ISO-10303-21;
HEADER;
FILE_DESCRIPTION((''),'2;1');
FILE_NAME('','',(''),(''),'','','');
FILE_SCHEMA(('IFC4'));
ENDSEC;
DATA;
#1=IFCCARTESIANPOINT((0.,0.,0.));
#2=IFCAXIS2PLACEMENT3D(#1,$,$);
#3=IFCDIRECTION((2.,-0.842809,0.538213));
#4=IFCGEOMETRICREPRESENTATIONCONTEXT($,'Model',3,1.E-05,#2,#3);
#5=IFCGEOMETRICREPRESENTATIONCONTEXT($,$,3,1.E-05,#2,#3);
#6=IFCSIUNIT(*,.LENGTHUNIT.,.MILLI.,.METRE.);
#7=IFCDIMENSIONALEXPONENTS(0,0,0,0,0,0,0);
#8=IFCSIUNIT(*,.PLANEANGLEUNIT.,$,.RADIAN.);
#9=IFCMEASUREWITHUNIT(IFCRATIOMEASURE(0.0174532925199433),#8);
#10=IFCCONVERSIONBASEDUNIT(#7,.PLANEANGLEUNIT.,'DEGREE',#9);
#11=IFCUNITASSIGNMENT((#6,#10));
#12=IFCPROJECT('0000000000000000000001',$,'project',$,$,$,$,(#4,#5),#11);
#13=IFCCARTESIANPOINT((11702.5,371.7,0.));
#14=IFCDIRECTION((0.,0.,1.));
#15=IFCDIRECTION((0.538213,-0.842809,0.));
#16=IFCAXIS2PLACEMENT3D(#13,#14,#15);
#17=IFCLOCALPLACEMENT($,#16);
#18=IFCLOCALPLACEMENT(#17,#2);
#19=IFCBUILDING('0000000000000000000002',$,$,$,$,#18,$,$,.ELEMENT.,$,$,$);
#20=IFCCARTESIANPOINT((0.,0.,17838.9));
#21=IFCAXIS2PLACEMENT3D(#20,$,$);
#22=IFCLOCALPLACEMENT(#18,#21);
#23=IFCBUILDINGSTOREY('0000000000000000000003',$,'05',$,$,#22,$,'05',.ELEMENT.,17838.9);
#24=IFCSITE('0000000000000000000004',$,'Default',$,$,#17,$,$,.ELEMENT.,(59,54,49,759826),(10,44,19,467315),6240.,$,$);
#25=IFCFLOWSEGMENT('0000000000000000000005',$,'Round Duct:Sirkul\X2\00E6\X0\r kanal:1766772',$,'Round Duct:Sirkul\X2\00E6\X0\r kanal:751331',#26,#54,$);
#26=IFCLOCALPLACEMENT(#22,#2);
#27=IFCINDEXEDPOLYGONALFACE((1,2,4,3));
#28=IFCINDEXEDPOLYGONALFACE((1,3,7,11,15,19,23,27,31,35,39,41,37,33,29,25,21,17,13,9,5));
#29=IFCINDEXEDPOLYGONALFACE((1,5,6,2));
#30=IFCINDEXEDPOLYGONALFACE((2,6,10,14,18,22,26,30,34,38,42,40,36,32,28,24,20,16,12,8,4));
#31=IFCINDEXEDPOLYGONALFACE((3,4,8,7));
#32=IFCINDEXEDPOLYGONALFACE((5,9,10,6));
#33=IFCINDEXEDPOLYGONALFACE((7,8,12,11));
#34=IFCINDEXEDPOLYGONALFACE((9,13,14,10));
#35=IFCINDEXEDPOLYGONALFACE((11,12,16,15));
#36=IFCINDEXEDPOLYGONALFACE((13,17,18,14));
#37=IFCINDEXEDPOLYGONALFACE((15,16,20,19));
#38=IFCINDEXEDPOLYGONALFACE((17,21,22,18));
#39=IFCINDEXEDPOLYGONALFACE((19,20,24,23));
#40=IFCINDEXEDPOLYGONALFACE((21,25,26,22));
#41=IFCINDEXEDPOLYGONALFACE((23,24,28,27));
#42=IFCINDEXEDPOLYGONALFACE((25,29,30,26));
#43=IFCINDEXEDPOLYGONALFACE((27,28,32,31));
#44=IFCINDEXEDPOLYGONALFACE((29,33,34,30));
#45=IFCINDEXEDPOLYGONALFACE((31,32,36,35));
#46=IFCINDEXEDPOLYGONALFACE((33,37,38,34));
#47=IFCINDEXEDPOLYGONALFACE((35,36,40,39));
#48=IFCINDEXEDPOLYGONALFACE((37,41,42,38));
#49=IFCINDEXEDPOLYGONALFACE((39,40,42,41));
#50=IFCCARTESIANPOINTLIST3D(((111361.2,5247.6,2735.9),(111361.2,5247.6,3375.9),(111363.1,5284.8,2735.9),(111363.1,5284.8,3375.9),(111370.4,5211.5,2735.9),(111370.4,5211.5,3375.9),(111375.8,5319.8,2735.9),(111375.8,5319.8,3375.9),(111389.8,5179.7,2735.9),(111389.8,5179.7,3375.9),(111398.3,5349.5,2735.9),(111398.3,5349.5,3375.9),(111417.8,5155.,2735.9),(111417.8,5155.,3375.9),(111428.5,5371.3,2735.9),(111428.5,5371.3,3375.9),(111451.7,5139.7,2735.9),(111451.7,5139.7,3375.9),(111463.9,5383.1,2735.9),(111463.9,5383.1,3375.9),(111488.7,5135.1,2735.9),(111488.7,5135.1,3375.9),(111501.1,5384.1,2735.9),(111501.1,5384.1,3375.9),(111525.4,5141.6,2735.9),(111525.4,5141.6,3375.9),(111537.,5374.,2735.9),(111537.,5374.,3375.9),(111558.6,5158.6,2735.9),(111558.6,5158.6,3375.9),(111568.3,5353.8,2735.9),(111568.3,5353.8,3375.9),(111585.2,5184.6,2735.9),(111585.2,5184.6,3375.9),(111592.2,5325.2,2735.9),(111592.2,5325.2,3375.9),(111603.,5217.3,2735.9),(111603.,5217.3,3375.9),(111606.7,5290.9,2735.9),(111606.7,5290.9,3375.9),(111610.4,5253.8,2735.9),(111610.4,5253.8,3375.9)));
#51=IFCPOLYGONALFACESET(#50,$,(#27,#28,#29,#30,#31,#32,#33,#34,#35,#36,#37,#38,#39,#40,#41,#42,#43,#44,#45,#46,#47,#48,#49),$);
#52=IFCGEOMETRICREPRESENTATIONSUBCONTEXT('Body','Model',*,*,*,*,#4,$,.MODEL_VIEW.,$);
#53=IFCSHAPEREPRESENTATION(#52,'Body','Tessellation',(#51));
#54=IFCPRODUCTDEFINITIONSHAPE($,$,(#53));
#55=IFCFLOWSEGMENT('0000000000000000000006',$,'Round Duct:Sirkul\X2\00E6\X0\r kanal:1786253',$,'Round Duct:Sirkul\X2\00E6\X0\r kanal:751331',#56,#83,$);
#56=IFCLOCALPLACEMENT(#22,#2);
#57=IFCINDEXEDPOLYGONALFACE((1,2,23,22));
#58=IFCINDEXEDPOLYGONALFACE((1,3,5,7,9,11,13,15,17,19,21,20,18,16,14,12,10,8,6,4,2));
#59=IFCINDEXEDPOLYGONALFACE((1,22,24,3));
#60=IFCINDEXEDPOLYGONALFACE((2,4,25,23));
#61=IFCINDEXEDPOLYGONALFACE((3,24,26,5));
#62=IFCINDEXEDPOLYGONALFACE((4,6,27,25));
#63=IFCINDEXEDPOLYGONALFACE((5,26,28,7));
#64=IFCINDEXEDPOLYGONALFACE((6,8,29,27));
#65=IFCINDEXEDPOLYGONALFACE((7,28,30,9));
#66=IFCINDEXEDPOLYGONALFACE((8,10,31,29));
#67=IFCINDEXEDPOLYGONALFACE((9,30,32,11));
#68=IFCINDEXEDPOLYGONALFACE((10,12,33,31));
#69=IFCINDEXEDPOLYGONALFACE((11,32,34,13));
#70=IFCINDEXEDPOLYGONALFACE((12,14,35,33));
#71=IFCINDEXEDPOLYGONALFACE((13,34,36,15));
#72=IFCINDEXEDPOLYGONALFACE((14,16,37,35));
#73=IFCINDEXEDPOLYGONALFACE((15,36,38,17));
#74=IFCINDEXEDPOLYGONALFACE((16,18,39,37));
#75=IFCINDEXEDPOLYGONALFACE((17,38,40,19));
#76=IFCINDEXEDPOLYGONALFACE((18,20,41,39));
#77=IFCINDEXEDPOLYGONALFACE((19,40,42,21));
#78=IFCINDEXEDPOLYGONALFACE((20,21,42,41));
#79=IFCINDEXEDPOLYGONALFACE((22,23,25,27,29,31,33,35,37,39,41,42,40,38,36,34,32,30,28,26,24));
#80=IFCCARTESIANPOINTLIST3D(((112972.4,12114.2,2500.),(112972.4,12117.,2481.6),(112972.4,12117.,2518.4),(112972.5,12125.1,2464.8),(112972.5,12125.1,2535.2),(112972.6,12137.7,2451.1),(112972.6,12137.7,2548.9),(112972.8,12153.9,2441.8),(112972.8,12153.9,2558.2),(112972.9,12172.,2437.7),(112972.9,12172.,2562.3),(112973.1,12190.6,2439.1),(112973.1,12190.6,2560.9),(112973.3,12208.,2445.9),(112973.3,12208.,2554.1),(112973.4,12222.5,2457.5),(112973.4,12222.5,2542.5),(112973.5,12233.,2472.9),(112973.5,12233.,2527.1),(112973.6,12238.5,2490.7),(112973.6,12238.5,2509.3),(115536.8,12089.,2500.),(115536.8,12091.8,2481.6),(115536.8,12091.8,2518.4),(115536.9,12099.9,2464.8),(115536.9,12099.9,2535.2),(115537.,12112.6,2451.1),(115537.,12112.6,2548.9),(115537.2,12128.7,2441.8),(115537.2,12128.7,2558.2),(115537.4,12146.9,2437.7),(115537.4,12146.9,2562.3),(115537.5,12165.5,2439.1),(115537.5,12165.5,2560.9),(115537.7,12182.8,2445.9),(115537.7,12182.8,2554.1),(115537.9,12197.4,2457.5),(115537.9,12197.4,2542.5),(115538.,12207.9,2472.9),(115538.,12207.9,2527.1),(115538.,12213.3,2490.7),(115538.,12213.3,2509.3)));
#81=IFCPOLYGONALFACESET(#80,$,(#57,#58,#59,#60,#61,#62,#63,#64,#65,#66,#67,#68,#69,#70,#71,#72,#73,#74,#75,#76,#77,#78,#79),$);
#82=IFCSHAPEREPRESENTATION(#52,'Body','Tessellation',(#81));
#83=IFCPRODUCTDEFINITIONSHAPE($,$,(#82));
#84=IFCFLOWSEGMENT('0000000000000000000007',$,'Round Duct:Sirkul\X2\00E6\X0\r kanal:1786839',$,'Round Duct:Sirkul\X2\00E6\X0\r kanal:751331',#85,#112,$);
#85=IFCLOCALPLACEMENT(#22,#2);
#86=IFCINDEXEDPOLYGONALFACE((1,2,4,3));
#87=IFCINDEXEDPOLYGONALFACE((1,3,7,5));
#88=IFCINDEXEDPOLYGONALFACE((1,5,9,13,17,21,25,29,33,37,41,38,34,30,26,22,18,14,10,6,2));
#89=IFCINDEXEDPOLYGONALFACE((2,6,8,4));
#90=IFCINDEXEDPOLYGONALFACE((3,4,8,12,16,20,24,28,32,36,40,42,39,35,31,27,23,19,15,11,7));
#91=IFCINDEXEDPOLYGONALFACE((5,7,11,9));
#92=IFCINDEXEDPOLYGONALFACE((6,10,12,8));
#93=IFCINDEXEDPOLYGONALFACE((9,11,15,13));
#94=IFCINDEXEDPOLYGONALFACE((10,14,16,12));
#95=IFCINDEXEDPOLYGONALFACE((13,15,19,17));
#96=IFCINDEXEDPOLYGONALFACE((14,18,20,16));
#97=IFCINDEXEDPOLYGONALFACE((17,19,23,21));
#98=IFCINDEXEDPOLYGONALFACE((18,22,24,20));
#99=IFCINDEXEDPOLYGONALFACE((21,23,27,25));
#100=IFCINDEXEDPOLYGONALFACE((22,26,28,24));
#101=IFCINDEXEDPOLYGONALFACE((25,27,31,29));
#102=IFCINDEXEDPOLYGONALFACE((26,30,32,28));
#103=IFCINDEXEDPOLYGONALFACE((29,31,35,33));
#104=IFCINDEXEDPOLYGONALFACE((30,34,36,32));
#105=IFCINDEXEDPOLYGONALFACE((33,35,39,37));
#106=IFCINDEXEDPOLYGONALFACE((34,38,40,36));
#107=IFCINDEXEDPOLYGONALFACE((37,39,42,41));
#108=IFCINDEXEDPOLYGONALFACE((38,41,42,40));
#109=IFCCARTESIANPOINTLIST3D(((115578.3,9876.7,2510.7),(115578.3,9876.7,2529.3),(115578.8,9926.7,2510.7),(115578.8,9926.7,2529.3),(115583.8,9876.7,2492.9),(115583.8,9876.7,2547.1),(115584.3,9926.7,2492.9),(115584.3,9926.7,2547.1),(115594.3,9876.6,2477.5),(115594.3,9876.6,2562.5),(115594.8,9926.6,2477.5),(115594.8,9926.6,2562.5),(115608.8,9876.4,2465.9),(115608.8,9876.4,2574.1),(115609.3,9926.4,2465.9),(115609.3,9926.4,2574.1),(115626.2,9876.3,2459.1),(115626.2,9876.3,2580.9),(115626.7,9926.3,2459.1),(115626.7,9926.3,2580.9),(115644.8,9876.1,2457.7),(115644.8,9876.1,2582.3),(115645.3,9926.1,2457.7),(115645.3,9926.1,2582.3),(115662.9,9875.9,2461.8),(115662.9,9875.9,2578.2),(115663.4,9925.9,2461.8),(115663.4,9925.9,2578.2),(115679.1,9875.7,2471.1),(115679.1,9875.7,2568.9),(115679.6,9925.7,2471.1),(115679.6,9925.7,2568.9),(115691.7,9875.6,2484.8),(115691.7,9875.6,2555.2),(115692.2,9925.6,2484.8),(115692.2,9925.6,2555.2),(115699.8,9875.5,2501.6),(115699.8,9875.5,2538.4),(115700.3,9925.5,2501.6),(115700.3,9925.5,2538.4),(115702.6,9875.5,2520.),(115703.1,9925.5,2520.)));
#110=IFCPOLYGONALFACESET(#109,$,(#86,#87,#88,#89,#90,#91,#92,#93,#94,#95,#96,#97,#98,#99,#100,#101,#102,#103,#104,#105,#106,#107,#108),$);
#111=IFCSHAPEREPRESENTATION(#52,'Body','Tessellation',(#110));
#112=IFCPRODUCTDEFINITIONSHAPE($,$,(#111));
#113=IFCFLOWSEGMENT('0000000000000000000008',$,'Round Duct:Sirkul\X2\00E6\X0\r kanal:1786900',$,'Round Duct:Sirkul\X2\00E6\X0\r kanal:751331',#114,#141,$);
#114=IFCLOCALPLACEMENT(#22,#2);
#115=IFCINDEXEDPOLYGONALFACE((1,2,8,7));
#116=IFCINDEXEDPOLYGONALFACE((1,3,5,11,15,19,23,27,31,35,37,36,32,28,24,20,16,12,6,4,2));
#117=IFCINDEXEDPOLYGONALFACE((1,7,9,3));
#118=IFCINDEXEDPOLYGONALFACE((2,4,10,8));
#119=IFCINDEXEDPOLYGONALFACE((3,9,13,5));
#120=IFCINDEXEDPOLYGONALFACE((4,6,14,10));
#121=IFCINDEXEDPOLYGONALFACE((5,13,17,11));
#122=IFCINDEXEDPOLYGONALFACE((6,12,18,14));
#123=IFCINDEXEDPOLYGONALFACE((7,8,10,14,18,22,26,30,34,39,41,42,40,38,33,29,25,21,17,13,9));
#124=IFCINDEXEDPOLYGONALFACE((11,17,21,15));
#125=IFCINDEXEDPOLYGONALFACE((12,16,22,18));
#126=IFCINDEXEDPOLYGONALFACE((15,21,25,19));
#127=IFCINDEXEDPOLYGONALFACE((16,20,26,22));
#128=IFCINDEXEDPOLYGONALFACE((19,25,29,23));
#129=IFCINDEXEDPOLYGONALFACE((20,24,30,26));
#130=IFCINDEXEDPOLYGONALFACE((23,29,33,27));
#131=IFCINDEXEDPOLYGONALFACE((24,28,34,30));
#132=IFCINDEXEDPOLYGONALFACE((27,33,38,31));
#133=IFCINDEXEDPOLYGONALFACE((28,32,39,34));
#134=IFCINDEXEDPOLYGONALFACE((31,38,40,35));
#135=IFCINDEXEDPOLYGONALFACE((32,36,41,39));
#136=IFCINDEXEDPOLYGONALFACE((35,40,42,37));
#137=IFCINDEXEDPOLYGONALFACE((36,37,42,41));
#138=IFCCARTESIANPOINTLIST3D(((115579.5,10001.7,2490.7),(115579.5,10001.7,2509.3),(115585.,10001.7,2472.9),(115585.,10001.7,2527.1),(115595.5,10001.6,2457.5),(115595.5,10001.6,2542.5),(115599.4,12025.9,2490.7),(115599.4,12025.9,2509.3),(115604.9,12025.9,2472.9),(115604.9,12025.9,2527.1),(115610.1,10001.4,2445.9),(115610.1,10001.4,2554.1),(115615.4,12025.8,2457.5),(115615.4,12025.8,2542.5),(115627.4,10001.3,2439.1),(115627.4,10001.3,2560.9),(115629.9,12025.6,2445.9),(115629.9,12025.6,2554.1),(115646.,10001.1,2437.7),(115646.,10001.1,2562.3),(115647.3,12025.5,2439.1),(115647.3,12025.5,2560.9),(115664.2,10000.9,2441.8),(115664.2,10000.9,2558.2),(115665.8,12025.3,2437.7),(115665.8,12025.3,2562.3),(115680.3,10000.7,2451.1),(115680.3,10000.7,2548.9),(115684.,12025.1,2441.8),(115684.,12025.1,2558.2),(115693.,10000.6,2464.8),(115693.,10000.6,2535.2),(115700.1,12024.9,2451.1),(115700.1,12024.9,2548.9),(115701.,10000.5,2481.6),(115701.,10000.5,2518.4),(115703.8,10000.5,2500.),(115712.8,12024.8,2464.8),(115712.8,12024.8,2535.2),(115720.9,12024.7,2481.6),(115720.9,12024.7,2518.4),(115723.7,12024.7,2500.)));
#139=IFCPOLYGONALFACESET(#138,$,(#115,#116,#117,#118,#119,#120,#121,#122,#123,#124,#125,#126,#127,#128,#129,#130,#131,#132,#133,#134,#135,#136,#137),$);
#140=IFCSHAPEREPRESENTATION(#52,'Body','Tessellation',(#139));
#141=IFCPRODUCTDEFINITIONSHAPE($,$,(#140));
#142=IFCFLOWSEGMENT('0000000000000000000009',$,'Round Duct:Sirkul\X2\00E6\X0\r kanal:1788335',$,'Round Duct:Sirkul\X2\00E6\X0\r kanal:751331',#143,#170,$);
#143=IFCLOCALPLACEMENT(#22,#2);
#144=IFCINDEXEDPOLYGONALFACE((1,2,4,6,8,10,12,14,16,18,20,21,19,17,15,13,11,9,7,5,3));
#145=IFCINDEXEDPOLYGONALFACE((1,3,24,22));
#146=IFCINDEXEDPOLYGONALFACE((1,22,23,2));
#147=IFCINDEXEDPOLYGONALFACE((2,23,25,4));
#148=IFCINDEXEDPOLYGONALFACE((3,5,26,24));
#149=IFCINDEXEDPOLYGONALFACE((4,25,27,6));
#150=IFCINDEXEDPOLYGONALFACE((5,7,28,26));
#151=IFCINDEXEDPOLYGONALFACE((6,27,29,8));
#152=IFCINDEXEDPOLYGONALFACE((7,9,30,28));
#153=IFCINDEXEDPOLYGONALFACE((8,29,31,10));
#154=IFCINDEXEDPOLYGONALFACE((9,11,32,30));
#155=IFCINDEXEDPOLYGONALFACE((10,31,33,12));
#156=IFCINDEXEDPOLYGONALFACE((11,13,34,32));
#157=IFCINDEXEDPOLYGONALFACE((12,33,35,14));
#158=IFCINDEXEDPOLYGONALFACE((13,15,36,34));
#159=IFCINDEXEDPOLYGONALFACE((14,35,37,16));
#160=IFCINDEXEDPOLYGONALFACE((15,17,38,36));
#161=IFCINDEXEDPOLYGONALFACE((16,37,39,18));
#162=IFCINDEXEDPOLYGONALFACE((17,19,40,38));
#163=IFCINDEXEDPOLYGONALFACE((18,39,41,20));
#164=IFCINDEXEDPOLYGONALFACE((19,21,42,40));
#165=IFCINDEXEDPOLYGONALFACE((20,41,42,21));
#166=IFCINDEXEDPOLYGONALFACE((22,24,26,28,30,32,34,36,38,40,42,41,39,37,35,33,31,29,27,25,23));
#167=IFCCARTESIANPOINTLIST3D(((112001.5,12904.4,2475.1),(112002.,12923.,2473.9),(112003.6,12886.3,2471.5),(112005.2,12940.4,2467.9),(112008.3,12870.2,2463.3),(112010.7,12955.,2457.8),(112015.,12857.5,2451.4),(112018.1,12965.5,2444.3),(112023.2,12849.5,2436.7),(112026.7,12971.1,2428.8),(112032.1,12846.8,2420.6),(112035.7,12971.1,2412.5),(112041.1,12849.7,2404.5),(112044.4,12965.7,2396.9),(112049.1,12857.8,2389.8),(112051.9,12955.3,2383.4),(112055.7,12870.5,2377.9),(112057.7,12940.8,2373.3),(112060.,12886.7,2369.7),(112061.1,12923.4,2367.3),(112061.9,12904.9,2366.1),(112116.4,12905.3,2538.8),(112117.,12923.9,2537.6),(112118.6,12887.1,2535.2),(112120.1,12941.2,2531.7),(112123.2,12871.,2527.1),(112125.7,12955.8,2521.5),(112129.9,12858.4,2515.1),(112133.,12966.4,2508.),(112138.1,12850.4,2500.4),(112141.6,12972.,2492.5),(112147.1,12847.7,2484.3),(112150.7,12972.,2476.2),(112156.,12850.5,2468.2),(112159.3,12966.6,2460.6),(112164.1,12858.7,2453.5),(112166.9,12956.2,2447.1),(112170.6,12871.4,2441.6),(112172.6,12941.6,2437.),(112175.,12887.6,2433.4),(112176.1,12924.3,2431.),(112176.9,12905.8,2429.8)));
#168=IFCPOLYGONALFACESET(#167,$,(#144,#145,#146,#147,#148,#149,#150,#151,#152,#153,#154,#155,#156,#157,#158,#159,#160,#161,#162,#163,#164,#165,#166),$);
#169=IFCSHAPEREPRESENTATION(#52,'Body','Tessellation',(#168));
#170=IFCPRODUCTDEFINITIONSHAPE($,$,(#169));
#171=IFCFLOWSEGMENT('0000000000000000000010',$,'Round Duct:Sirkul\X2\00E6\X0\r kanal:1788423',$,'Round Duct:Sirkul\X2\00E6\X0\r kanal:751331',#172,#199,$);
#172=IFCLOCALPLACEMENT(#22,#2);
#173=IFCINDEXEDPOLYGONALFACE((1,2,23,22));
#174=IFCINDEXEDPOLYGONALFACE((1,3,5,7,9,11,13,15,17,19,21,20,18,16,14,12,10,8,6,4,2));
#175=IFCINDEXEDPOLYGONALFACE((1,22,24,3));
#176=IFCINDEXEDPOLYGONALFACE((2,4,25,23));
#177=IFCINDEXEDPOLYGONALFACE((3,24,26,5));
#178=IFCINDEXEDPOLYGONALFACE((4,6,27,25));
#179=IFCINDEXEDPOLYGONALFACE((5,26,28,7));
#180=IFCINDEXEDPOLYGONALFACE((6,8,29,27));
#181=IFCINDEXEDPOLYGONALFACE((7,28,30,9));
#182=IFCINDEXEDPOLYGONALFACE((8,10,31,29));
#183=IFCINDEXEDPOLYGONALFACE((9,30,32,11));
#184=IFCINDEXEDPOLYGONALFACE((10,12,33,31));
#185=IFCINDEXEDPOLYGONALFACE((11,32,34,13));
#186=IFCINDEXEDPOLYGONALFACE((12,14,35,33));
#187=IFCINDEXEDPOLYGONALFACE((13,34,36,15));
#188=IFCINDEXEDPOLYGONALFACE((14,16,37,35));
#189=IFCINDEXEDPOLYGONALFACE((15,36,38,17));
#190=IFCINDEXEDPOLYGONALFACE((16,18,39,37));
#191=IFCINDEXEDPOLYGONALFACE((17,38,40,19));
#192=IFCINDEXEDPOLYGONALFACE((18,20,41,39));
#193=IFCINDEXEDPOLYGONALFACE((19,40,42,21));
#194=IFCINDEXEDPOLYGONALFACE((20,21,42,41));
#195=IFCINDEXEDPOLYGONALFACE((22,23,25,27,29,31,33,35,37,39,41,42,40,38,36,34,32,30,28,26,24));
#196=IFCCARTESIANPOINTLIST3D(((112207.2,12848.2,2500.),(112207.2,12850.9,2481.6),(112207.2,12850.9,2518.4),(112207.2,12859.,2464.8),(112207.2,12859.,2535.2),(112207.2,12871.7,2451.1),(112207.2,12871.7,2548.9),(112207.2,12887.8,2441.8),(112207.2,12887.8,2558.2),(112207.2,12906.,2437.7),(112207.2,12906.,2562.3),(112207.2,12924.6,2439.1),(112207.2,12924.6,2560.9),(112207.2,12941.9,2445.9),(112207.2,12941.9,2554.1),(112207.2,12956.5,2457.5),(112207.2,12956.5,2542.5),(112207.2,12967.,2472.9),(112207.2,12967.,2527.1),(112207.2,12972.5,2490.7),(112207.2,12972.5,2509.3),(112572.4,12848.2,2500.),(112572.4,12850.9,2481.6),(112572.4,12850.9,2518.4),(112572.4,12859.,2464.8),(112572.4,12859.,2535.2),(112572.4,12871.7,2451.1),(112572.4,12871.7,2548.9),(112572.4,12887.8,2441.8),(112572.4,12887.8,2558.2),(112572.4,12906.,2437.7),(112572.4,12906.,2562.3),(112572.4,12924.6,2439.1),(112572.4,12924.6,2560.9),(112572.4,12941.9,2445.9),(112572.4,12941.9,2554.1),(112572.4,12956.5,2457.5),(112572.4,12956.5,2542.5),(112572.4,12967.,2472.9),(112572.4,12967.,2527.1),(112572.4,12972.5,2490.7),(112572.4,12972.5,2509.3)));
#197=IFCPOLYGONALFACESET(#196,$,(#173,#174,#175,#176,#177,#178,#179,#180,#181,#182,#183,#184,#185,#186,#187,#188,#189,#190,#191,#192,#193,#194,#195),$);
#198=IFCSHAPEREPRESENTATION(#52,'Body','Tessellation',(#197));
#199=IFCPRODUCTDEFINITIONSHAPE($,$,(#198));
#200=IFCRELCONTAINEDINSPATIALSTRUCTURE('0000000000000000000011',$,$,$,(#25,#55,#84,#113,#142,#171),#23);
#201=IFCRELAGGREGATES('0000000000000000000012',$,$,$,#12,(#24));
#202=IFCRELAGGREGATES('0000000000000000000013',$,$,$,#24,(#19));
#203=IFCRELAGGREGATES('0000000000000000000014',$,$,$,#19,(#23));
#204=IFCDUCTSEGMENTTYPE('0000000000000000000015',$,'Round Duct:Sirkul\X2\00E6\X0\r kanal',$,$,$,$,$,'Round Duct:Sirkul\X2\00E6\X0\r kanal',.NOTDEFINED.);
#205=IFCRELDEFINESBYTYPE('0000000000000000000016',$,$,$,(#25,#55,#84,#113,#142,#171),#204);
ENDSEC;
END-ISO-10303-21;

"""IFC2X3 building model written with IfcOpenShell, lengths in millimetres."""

from ifc_helpers import new_model, entity, si_unit, converted_unit, direction, frame, frame_2d, origin, origin_2d_with_axis, place, context, subcontext, project, spatial, circle, extrude, type_object, element, save


model = new_model("IFC2X3")

# Units and contexts
model_context = context("Model", 3, precision=1e-05, world=origin(), true_north=direction((2.0, -0.842809, 0.538213)))
context_of_model = context(None, 3, precision=1e-05, world=origin(), true_north=direction((2.0, -0.842809, 0.538213)))
body_context = subcontext(model_context, "Body", "Model", "MODEL_VIEW")
ifc_project = project(units=[si_unit("LENGTHUNIT", "METRE", prefix="MILLI"), converted_unit("PLANEANGLEUNIT", "DEGREE", entity("IfcRatioMeasure", 0.0174532925199433), si_unit("PLANEANGLEUNIT", "RADIAN"), dimensions=[0, 0, 0, 0, 0, 0, 0])], contexts=[model_context, context_of_model])

# Site, building, storey
site_placement = place(None, frame((11702.5, 371.7, 0.0), z_axis=(0.0, 0.0, 1.0), x_axis=(0.538213, -0.842809, 0.0)))
site = spatial("IfcSite", under=ifc_project, at=site_placement, Name="Default", CompositionType="ELEMENT", RefLatitude=(59, 54, 49, 759826), RefLongitude=(10, 44, 19, 467315), RefElevation=6240.0)
building_placement = place(site_placement, origin())
building = spatial("IfcBuilding", under=site, at=building_placement, CompositionType="ELEMENT")
storey_placement = place(building_placement, frame((0.0, 0.0, 17838.9)))
storey = spatial("IfcBuildingStorey", under=building, at=storey_placement, Name="05", LongName="05", CompositionType="ELEMENT", Elevation=17838.9)

# Flow segments
duct_segment_type = type_object("IfcDuctSegmentType", Name="Round Duct:Sirkulær kanal", ElementType="Round Duct:Sirkulær kanal", PredefinedType="NOTDEFINED")
flow_segment_1_placement = place(storey_placement, origin())
element("IfcFlowSegment", 1, at=flow_segment_1_placement, inside=storey, type_object=duct_segment_type, Name="Round Duct:Sirkulær kanal:1766772", ObjectType="Round Duct:Sirkulær kanal:751331", context=body_context, shape_type="SweptSolid", body=[
    extrude(circle(Radius=125.0, at=origin_2d_with_axis()), frame((111485.6, 5260.0, 2735.9), z_axis=(0.0, 0.0, 1.0), x_axis=(0.025094, -0.999685, 0.0)), (0.0, 0.0, 1.0), 640.0),
])
flow_segment_2_placement = place(storey_placement, origin())
element("IfcFlowSegment", 2, at=flow_segment_2_placement, inside=storey, type_object=duct_segment_type, Name="Round Duct:Sirkulær kanal:1786253", ObjectType="Round Duct:Sirkulær kanal:751331", context=body_context, shape_type="SweptSolid", body=[
    extrude(circle(Radius=62.5, at=origin_2d_with_axis()), frame((112973.0, 12176.7, 2500.0), z_axis=(0.999952, -0.00981, 0.0), x_axis=(-0.00981, -0.999952, 0.0)), (0.0, 0.0, 1.0), 2564.6),
])
flow_segment_3_placement = place(storey_placement, origin())
element("IfcFlowSegment", 3, at=flow_segment_3_placement, inside=storey, type_object=duct_segment_type, Name="Round Duct:Sirkulær kanal:1786839", ObjectType="Round Duct:Sirkulær kanal:751331", context=body_context, shape_type="SweptSolid", body=[
    extrude(circle(Radius=62.5, at=frame_2d((0.0, 0.0), x_axis=(1.0, 0.0))), frame((115640.1, 9876.1, 2520.0), z_axis=(0.00981, 0.999952, 0.0), x_axis=(0.999952, -0.00981, 0.0)), (0.0, 0.0, 1.0), 50.0),
])
flow_segment_4_placement = place(storey_placement, origin())
element("IfcFlowSegment", 4, at=flow_segment_4_placement, inside=storey, type_object=duct_segment_type, Name="Round Duct:Sirkulær kanal:1786900", ObjectType="Round Duct:Sirkulær kanal:751331", context=body_context, shape_type="SweptSolid", body=[
    extrude(circle(Radius=62.5, at=origin_2d_with_axis()), frame((115641.3, 10001.1, 2500.0), z_axis=(0.00981, 0.999952, 0.0), x_axis=(0.999952, -0.00981, 0.0)), (0.0, 0.0, 1.0), 2024.3),
])
flow_segment_5_placement = place(storey_placement, origin())
element("IfcFlowSegment", 5, at=flow_segment_5_placement, inside=storey, type_object=duct_segment_type, Name="Round Duct:Sirkulær kanal:1788335", ObjectType="Round Duct:Sirkulær kanal:751331", context=body_context, shape_type="SweptSolid", body=[
    extrude(circle(Radius=62.5, at=origin_2d_with_axis()), frame((112031.7, 12909.3, 2420.6), z_axis=(0.874594, 0.006685, 0.48481), x_axis=(0.007643, -0.999971, 0.0)), (0.0, 0.0, 1.0), 131.4),
])
flow_segment_6_placement = place(storey_placement, origin())
element("IfcFlowSegment", 6, at=flow_segment_6_placement, inside=storey, type_object=duct_segment_type, Name="Round Duct:Sirkulær kanal:1788423", ObjectType="Round Duct:Sirkulær kanal:751331", context=body_context, shape_type="SweptSolid", body=[
    extrude(circle(Radius=62.5, at=origin_2d_with_axis()), frame((112207.2, 12910.7, 2500.0), z_axis=(1.0, 0.0, 0.0), x_axis=(0.0, -1.0, 0.0)), (0.0, 0.0, 1.0), 365.1),
])

save(model, "model.ifc")
